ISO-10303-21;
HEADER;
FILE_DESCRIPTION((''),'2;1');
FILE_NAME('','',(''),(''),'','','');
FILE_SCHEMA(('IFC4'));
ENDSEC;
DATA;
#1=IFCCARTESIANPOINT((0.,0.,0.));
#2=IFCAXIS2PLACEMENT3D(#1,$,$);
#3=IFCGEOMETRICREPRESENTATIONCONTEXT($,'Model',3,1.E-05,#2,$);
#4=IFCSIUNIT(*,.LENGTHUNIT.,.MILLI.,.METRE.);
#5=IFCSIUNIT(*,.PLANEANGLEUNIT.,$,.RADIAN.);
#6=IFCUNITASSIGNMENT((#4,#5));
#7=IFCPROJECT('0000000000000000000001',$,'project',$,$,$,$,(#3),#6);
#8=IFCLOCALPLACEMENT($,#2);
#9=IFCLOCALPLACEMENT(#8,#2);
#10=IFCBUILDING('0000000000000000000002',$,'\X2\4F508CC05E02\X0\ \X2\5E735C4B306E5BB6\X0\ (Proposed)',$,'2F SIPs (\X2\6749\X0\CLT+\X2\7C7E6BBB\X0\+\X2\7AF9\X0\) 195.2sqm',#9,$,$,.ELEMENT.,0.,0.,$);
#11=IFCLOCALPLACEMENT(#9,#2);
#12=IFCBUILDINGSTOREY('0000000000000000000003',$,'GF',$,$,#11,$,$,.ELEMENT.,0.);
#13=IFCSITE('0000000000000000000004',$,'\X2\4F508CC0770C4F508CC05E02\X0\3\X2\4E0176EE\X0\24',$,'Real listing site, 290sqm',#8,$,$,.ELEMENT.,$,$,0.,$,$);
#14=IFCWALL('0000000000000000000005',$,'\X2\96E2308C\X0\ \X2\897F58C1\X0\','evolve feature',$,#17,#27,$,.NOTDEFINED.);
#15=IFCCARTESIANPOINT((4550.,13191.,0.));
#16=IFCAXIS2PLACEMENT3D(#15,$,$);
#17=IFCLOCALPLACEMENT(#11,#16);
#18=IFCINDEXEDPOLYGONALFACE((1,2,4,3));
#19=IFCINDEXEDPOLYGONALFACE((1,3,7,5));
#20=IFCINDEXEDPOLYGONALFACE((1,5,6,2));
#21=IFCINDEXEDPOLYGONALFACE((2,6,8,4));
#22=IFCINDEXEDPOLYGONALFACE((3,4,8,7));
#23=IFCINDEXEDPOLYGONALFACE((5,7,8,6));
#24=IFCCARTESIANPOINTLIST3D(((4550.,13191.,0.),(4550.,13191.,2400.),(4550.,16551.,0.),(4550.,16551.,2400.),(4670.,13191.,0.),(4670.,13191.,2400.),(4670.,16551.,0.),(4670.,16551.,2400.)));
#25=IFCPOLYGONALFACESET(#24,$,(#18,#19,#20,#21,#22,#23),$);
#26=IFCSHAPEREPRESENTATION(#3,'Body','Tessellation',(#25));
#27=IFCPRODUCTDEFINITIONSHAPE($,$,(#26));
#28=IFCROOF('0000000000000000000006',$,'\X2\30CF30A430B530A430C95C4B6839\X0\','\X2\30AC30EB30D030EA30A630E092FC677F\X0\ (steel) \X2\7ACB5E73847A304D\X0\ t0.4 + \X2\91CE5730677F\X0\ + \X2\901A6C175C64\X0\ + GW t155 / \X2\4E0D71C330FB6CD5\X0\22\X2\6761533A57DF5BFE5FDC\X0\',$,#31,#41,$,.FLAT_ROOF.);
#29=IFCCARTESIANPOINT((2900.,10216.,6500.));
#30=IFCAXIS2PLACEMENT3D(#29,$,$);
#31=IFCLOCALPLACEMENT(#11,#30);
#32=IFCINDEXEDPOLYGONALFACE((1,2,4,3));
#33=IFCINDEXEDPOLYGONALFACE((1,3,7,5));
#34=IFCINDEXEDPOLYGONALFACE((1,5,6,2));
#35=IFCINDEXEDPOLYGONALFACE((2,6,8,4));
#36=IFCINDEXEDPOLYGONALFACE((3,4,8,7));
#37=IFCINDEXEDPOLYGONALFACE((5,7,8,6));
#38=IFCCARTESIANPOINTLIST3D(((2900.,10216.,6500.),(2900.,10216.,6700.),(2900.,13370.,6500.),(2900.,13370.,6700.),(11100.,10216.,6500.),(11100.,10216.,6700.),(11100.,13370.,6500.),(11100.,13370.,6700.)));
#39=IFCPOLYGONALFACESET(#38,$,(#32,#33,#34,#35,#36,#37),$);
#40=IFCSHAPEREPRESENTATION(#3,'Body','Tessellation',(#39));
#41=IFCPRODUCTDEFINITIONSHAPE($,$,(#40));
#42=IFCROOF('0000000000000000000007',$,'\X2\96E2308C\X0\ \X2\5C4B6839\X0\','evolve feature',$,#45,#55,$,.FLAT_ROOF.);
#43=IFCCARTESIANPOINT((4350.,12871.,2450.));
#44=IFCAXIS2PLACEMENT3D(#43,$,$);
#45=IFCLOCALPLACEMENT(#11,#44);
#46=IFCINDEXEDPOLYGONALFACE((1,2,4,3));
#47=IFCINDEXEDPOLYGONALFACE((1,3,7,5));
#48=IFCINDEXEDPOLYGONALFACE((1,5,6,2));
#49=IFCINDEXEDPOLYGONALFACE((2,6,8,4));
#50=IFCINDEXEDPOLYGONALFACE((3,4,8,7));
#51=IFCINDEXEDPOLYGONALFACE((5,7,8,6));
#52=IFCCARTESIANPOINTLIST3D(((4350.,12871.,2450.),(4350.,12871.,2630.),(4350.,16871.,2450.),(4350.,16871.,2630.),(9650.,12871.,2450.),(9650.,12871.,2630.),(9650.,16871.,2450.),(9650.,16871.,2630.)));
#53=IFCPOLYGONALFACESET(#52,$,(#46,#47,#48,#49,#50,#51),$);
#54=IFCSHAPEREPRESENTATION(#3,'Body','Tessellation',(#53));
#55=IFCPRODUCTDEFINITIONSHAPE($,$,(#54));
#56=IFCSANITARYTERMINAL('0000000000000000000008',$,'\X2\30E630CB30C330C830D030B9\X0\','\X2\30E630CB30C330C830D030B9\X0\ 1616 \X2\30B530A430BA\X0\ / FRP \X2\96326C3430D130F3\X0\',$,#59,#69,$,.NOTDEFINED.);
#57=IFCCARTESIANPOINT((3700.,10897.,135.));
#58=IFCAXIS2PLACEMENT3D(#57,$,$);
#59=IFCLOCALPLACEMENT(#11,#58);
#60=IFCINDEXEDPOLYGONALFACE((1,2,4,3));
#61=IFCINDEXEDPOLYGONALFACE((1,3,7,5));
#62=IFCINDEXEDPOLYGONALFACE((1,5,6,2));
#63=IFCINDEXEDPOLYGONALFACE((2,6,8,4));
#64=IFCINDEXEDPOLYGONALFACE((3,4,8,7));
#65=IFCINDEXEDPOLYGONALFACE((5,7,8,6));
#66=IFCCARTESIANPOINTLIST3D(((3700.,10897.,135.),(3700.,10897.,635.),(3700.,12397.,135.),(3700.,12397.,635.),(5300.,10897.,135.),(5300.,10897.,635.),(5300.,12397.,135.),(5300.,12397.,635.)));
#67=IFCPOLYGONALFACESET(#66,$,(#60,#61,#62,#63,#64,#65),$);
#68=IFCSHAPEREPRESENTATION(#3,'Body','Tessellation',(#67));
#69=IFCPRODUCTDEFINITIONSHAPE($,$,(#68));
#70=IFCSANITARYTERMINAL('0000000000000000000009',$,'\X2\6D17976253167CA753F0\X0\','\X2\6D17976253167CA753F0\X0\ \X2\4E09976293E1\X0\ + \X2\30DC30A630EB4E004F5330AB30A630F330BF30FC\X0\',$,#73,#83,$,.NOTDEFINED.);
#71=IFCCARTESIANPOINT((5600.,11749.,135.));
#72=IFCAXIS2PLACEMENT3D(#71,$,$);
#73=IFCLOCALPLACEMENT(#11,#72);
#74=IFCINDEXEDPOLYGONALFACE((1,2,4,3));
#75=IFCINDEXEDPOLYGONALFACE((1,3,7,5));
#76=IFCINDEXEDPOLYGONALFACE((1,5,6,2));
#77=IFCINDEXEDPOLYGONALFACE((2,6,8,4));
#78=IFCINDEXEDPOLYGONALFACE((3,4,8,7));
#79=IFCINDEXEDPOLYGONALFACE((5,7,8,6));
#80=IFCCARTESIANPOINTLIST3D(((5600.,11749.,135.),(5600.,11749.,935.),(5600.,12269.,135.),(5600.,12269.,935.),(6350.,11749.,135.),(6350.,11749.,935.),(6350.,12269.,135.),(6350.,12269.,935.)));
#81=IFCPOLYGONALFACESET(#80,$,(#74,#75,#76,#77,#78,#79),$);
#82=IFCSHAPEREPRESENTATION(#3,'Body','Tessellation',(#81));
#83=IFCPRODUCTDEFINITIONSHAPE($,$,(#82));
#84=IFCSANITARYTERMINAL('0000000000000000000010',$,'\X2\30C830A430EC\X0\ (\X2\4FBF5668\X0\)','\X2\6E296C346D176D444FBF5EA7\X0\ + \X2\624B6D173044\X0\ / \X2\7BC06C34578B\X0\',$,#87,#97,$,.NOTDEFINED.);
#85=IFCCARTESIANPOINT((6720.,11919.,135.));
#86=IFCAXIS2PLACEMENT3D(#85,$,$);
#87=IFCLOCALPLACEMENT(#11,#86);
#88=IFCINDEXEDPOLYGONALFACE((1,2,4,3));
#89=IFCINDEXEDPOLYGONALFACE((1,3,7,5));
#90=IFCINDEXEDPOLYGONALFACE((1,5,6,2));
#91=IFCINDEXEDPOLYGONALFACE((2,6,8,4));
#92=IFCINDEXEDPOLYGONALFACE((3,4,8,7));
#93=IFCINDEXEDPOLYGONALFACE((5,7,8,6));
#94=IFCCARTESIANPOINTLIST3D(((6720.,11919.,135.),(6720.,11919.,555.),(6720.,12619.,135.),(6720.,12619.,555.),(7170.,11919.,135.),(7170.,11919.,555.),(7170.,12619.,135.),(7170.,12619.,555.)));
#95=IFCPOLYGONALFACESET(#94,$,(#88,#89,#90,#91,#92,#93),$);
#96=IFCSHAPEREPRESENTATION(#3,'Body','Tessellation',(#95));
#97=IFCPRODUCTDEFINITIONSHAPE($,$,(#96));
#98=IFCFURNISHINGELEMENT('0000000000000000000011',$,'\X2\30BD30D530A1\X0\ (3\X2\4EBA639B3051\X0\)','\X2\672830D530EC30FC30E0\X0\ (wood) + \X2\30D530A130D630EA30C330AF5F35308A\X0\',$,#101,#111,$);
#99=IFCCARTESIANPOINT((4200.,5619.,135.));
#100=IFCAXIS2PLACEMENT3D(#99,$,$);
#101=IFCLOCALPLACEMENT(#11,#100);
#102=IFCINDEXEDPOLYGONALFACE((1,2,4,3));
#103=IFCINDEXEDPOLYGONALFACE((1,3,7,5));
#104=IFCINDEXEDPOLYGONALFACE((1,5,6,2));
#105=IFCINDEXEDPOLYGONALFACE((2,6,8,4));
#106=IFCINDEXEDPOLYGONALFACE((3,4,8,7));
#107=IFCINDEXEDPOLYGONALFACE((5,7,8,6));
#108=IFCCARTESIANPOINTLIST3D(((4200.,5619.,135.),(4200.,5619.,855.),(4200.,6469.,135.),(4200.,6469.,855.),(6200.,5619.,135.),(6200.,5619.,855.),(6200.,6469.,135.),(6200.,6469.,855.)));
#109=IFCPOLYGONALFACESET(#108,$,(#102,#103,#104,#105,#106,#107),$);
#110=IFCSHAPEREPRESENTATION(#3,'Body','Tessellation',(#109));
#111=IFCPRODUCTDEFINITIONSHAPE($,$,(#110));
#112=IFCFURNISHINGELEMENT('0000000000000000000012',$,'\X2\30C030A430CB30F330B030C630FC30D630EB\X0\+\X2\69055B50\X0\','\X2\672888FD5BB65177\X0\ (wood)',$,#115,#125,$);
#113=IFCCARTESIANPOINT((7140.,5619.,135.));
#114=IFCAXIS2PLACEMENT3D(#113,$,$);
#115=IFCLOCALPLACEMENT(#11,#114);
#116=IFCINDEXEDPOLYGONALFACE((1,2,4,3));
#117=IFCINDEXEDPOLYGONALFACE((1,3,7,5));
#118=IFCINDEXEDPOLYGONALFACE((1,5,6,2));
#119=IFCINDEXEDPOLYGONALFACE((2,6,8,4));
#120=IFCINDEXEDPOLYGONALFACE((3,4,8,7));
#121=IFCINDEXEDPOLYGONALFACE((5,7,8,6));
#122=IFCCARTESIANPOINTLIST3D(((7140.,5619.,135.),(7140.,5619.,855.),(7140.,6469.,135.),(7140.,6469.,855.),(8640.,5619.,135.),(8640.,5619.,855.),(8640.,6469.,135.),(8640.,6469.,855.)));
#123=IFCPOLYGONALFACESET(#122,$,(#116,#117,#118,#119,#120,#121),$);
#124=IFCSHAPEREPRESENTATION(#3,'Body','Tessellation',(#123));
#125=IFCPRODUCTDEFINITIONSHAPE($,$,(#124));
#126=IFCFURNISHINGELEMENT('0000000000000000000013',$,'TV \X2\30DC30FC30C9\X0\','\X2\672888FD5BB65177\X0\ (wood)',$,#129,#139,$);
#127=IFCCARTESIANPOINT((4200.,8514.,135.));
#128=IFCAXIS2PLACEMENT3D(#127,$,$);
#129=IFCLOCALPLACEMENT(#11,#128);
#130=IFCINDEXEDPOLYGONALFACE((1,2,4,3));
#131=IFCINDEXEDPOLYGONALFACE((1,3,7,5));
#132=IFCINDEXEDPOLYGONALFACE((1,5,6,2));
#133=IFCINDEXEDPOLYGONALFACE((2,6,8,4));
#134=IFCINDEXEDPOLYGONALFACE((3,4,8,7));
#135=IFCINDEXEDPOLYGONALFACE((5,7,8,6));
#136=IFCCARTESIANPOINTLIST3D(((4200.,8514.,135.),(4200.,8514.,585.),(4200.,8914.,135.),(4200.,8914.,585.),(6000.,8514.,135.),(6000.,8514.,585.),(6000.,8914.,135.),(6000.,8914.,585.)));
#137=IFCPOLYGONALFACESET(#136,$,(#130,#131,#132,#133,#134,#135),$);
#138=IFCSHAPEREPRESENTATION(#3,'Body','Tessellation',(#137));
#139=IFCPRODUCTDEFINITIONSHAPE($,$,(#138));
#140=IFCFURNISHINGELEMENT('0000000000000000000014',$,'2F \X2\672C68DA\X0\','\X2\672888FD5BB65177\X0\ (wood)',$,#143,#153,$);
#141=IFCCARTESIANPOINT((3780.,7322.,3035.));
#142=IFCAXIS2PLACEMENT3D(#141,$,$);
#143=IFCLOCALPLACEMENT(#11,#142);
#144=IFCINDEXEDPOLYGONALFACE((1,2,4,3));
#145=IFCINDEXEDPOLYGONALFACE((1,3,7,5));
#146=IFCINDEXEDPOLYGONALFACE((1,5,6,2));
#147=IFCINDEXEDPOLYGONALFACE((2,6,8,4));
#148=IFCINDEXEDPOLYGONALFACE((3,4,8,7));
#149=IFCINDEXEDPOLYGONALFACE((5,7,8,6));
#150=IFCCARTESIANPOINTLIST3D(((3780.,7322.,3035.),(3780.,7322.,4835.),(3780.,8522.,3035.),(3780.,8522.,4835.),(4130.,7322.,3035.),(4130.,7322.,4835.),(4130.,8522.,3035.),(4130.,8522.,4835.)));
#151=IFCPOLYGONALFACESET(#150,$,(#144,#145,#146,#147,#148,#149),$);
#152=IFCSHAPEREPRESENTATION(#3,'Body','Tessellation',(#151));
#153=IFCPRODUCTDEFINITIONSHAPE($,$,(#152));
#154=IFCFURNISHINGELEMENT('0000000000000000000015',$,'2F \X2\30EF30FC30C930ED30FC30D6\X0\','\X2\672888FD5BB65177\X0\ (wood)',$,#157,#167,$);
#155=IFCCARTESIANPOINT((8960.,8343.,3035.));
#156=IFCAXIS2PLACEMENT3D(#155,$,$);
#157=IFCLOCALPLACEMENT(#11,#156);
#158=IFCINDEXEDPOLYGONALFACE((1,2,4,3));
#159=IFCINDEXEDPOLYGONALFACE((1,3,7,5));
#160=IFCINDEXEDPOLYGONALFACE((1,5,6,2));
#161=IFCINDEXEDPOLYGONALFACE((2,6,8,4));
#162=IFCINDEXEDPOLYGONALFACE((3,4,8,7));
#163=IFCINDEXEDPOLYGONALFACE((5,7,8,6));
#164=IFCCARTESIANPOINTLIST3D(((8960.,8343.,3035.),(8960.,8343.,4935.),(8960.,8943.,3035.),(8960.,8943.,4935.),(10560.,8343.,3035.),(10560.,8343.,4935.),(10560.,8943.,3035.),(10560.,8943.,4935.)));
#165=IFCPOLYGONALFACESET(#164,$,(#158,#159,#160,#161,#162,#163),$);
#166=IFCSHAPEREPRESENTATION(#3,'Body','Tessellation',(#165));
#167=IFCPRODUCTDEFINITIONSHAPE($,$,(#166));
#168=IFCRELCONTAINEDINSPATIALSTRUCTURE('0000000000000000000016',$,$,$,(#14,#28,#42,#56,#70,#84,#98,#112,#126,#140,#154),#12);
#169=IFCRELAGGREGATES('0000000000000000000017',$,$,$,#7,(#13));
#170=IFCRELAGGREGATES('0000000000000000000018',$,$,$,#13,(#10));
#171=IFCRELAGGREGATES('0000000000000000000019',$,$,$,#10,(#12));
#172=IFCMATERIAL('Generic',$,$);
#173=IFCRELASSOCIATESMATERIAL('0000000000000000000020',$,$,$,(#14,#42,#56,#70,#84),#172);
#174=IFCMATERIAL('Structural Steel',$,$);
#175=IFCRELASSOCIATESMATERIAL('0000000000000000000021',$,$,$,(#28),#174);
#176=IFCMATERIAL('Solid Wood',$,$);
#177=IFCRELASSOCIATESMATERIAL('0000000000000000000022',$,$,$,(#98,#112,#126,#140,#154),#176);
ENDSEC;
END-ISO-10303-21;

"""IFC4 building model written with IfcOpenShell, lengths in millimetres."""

from ifc_helpers import new_model, si_unit, frame, frame_2d, origin, place, context, project, spatial, rectangle, extrude, material, element, save


model = new_model("IFC4")

# Units and contexts
model_context = context("Model", 3, precision=1e-05, world=origin())
ifc_project = project(units=[si_unit("LENGTHUNIT", "METRE", prefix="MILLI"), si_unit("PLANEANGLEUNIT", "RADIAN")], contexts=[model_context])

# Site, building, storey
site_placement = place(None, origin())
site = spatial("IfcSite", under=ifc_project, at=site_placement, Name="佐賀県佐賀市3丁目24", ObjectType="Real listing site, 290sqm", CompositionType="ELEMENT", RefElevation=0.0)
building_placement = place(site_placement, origin())
building = spatial("IfcBuilding", under=site, at=building_placement, Name="佐賀市 平屋の家 (Proposed)", ObjectType="2F SIPs (杉CLT+籾殻+竹) 195.2sqm", CompositionType="ELEMENT", ElevationOfRefHeight=0.0, ElevationOfTerrain=0.0)
storey_placement = place(building_placement, origin())
storey = spatial("IfcBuildingStorey", under=building, at=storey_placement, Name="GF", CompositionType="ELEMENT", Elevation=0.0)

# Shared definitions
ifc_material_1 = material(Name="Generic")

# Shared definitions
ifc_material_2 = material(Name="Solid Wood")

# Wall
wall_1_placement = place(storey_placement, frame((4550.0, 13191.0, 0.0)))
element("IfcWall", 1, at=wall_1_placement, inside=storey, material=ifc_material_1, Name="離れ 西壁", Description="evolve feature", PredefinedType="NOTDEFINED", context=model_context, shape_type="SweptSolid", body=[
    extrude(rectangle(XDim=120.0, YDim=3360.0, at=frame_2d((60.0, 1680.0))), frame((4550.0, 13191.0, 0.0)), (0.0, 0.0, 1.0), 2400.0),
])

# Roofs
ifc_material_3 = material(Name="Structural Steel")
roof_1_placement = place(storey_placement, frame((2900.0, 10216.0, 6500.0)))
element("IfcRoof", 2, at=roof_1_placement, inside=storey, material=ifc_material_3, Name="ハイサイド屋根", Description="ガルバリウム鋼板 (steel) 立平葺き t0.4 + 野地板 + 通気層 + GW t155 / 不燃・法22条区域対応", PredefinedType="FLAT_ROOF", context=model_context, shape_type="SweptSolid", body=[
    extrude(rectangle(XDim=8200.0, YDim=3154.0, at=frame_2d((4100.0, 1577.0))), frame((2900.0, 10216.0, 6500.0)), (0.0, 0.0, 1.0), 200.0),
])
roof_2_placement = place(storey_placement, frame((4350.0, 12871.0, 2450.0)))
element("IfcRoof", 3, at=roof_2_placement, inside=storey, material=ifc_material_1, Name="離れ 屋根", Description="evolve feature", PredefinedType="FLAT_ROOF", context=model_context, shape_type="SweptSolid", body=[
    extrude(rectangle(XDim=5300.0, YDim=4000.0, at=frame_2d((2650.0, 2000.0))), frame((4350.0, 12871.0, 2450.0)), (0.0, 0.0, 1.0), 180.0),
])

# Sanitary terminals
sanitary_terminal_1_placement = place(storey_placement, frame((3700.0, 10897.0, 135.0)))
element("IfcSanitaryTerminal", 4, at=sanitary_terminal_1_placement, inside=storey, material=ifc_material_1, Name="ユニットバス", Description="ユニットバス 1616 サイズ / FRP 防水パン", PredefinedType="NOTDEFINED", context=model_context, shape_type="SweptSolid", body=[
    extrude(rectangle(XDim=1600.0, YDim=1500.0, at=frame_2d((800.0, 750.0))), frame((3700.0, 10897.0, 135.0)), (0.0, 0.0, 1.0), 500.0),
])
sanitary_terminal_2_placement = place(storey_placement, frame((5600.0, 11749.0, 135.0)))
element("IfcSanitaryTerminal", 5, at=sanitary_terminal_2_placement, inside=storey, material=ifc_material_1, Name="洗面化粧台", Description="洗面化粧台 三面鏡 + ボウル一体カウンター", PredefinedType="NOTDEFINED", context=model_context, shape_type="SweptSolid", body=[
    extrude(rectangle(XDim=750.0, YDim=520.0, at=frame_2d((375.0, 260.0))), frame((5600.0, 11749.0, 135.0)), (0.0, 0.0, 1.0), 800.0),
])
sanitary_terminal_3_placement = place(storey_placement, frame((6720.0, 11919.0, 135.0)))
element("IfcSanitaryTerminal", 6, at=sanitary_terminal_3_placement, inside=storey, material=ifc_material_1, Name="トイレ (便器)", Description="温水洗浄便座 + 手洗い / 節水型", PredefinedType="NOTDEFINED", context=model_context, shape_type="SweptSolid", body=[
    extrude(rectangle(XDim=450.0, YDim=700.0, at=frame_2d((225.0, 350.0))), frame((6720.0, 11919.0, 135.0)), (0.0, 0.0, 1.0), 420.0),
])

# Furnishing elements
furnishing_1_placement = place(storey_placement, frame((4200.0, 5619.0, 135.0)))
element("IfcFurnishingElement", 7, at=furnishing_1_placement, inside=storey, material=ifc_material_2, Name="ソファ (3人掛け)", Description="木フレーム (wood) + ファブリック張り", context=model_context, shape_type="SweptSolid", body=[
    extrude(rectangle(XDim=2000.0, YDim=850.0, at=frame_2d((1000.0, 425.0))), frame((4200.0, 5619.0, 135.0)), (0.0, 0.0, 1.0), 720.0),
])
furnishing_2_placement = place(storey_placement, frame((7140.0, 5619.0, 135.0)))
element("IfcFurnishingElement", 8, at=furnishing_2_placement, inside=storey, material=ifc_material_2, Name="ダイニングテーブル+椅子", Description="木製家具 (wood)", context=model_context, shape_type="SweptSolid", body=[
    extrude(rectangle(XDim=1500.0, YDim=850.0, at=frame_2d((750.0, 425.0))), frame((7140.0, 5619.0, 135.0)), (0.0, 0.0, 1.0), 720.0),
])
furnishing_3_placement = place(storey_placement, frame((4200.0, 8514.0, 135.0)))
element("IfcFurnishingElement", 9, at=furnishing_3_placement, inside=storey, material=ifc_material_2, Name="TV ボード", Description="木製家具 (wood)", context=model_context, shape_type="SweptSolid", body=[
    extrude(rectangle(XDim=1800.0, YDim=400.0, at=frame_2d((900.0, 200.0))), frame((4200.0, 8514.0, 135.0)), (0.0, 0.0, 1.0), 450.0),
])
furnishing_4_placement = place(storey_placement, frame((3780.0, 7322.0, 3035.0)))
element("IfcFurnishingElement", 10, at=furnishing_4_placement, inside=storey, material=ifc_material_2, Name="2F 本棚", Description="木製家具 (wood)", context=model_context, shape_type="SweptSolid", body=[
    extrude(rectangle(XDim=350.0, YDim=1200.0, at=frame_2d((175.0, 600.0))), frame((3780.0, 7322.0, 3035.0)), (0.0, 0.0, 1.0), 1800.0),
])
furnishing_5_placement = place(storey_placement, frame((8960.0, 8343.0, 3035.0)))
element("IfcFurnishingElement", 11, at=furnishing_5_placement, inside=storey, material=ifc_material_2, Name="2F ワードローブ", Description="木製家具 (wood)", context=model_context, shape_type="SweptSolid", body=[
    extrude(rectangle(XDim=1600.0, YDim=600.0, at=frame_2d((800.0, 300.0))), frame((8960.0, 8343.0, 3035.0)), (0.0, 0.0, 1.0), 1900.0),
])

save(model, "model.ifc")
